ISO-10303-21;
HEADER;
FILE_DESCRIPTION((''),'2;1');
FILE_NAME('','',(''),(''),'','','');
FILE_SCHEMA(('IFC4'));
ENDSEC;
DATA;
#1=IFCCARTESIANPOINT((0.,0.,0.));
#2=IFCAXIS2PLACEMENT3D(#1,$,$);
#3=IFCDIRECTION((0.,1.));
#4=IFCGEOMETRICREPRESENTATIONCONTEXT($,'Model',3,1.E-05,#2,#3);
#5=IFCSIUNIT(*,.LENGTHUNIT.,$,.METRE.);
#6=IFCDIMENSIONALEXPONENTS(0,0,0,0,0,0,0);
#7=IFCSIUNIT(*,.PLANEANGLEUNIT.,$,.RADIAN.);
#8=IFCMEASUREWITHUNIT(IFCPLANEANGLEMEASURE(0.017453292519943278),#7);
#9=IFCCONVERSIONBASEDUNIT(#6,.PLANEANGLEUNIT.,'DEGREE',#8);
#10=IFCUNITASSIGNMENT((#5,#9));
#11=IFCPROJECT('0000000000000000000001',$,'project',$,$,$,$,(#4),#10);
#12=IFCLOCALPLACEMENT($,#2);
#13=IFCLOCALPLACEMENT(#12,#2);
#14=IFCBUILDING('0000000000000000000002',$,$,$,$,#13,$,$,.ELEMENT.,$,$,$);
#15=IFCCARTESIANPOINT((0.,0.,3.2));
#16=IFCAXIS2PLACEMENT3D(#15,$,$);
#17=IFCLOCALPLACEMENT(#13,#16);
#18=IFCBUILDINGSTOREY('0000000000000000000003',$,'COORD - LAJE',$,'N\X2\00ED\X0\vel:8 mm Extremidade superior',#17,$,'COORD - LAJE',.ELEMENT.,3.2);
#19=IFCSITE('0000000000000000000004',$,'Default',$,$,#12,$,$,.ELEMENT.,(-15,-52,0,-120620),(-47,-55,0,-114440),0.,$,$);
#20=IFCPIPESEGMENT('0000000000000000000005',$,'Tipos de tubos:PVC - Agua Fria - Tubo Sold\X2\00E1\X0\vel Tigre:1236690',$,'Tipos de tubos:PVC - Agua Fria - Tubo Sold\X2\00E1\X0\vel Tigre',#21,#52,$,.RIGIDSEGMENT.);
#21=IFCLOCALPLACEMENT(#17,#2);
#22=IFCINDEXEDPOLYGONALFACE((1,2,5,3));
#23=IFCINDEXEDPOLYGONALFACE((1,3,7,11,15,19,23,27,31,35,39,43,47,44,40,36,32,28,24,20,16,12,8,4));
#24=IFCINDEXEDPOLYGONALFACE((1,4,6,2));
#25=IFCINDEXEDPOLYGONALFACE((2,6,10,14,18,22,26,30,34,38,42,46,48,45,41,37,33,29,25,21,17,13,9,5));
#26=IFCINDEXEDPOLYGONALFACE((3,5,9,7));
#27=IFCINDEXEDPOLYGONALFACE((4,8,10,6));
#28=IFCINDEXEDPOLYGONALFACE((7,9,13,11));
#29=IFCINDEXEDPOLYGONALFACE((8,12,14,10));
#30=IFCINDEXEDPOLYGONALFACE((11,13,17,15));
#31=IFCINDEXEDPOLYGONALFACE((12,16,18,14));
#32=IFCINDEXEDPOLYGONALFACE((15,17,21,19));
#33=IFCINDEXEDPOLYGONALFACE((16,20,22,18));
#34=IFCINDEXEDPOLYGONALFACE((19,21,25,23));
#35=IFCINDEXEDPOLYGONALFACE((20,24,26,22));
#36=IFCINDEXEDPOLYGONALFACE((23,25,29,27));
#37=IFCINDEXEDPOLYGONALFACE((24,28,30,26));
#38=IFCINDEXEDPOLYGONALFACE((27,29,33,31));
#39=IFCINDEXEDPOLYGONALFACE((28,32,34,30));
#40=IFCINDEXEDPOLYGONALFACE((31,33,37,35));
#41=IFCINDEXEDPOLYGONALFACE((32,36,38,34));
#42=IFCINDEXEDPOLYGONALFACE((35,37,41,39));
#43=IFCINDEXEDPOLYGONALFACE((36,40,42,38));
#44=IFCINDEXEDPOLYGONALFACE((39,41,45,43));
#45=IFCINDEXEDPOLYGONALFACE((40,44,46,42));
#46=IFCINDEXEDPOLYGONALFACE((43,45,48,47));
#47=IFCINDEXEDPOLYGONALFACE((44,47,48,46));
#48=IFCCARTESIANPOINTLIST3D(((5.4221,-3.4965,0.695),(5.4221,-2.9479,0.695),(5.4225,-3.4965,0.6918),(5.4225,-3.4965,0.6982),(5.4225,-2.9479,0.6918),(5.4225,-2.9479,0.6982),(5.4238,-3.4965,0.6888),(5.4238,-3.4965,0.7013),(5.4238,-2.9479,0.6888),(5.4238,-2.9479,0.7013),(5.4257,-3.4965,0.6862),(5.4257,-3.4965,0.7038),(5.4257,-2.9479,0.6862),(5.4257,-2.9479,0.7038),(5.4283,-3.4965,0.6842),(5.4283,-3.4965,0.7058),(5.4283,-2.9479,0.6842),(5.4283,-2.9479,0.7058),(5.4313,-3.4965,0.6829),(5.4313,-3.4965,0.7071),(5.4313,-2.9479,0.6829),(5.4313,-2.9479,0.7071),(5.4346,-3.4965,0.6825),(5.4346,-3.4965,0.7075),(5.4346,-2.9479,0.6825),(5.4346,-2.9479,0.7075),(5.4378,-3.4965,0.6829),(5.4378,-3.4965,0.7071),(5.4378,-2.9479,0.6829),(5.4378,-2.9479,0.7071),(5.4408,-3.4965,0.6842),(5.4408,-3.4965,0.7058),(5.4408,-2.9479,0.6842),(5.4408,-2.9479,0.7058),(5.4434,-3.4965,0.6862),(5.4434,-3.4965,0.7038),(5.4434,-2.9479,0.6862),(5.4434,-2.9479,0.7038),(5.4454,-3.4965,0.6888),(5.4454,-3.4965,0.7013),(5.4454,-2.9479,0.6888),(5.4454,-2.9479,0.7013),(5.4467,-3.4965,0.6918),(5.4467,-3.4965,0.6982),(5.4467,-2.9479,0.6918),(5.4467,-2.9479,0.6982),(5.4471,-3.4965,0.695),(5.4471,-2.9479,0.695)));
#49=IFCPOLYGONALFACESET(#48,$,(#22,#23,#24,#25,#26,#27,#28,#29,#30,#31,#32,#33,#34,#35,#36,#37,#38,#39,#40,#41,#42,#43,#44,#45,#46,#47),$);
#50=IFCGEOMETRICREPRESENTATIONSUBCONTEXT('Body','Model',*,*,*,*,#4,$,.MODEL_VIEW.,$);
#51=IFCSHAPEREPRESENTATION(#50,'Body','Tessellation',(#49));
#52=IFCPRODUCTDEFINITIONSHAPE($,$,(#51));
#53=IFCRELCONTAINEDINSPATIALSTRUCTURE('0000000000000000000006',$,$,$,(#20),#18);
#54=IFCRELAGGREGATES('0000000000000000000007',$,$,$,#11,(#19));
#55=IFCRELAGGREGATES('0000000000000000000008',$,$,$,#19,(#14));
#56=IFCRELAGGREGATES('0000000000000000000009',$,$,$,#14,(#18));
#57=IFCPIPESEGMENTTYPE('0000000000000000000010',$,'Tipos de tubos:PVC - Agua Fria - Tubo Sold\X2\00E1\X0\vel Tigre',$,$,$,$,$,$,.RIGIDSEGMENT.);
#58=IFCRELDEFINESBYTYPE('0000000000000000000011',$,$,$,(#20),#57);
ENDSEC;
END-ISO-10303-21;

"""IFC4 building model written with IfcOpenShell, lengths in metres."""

from ifc_helpers import new_model, entity, si_unit, converted_unit, direction, frame, origin, place, context, subcontext, project, spatial, arc, indexed_curve, outline, extrude, type_object, element, save


model = new_model("IFC4")

# Units and contexts
model_context = context("Model", 3, precision=1e-05, world=origin(), true_north=direction((0.0, 1.0)))
body_context = subcontext(model_context, "Body", "Model", "MODEL_VIEW")
ifc_project = project(units=[si_unit("LENGTHUNIT", "METRE"), converted_unit("PLANEANGLEUNIT", "DEGREE", entity("IfcPlaneAngleMeasure", 0.017453292519943278), si_unit("PLANEANGLEUNIT", "RADIAN"), dimensions=[0, 0, 0, 0, 0, 0, 0])], contexts=[model_context])

# Site, building, storey
site_placement = place(None, origin())
site = spatial("IfcSite", under=ifc_project, at=site_placement, Name="Default", CompositionType="ELEMENT", RefLatitude=(-15, -52, 0, -120620), RefLongitude=(-47, -55, 0, -114440), RefElevation=0.0)
building_placement = place(site_placement, origin())
building = spatial("IfcBuilding", under=site, at=building_placement, CompositionType="ELEMENT")
storey_placement = place(building_placement, frame((0.0, 0.0, 3.2)))
storey = spatial("IfcBuildingStorey", under=building, at=storey_placement, Name="COORD - LAJE", ObjectType="Nível:8 mm Extremidade superior", LongName="COORD - LAJE", CompositionType="ELEMENT", Elevation=3.2)

# Pipe segment
pipe_segment_type = type_object("IfcPipeSegmentType", Name="Tipos de tubos:PVC - Agua Fria - Tubo Soldável Tigre", PredefinedType="RIGIDSEGMENT")
pipe_segment_1_placement = place(storey_placement, origin())
element("IfcPipeSegment", 1, at=pipe_segment_1_placement, inside=storey, type_object=pipe_segment_type, Name="Tipos de tubos:PVC - Agua Fria - Tubo Soldável Tigre:1236690", ObjectType="Tipos de tubos:PVC - Agua Fria - Tubo Soldável Tigre", PredefinedType="RIGIDSEGMENT", context=body_context, shape_type="SweptSolid", body=[
    extrude(outline(indexed_curve([(0.0125, 0.0), (0.0088, 0.0088), (0.0, 0.0125), (-0.0088, 0.0088), (-0.0125, 0.0), (-0.0088, -0.0088), (0.0, -0.0125), (0.0088, -0.0088)], segments=[arc(1, 2, 3), arc(3, 4, 5), arc(5, 6, 7), arc(7, 8, 1)], self_intersect=False)), frame((5.4346, -3.4965, 0.695), z_axis=(0.0, 1.0, 0.0), x_axis=(1.0, 0.0, 0.0)), (0.0, 0.0, 1.0), 0.5486),
])

save(model, "model.ifc")
